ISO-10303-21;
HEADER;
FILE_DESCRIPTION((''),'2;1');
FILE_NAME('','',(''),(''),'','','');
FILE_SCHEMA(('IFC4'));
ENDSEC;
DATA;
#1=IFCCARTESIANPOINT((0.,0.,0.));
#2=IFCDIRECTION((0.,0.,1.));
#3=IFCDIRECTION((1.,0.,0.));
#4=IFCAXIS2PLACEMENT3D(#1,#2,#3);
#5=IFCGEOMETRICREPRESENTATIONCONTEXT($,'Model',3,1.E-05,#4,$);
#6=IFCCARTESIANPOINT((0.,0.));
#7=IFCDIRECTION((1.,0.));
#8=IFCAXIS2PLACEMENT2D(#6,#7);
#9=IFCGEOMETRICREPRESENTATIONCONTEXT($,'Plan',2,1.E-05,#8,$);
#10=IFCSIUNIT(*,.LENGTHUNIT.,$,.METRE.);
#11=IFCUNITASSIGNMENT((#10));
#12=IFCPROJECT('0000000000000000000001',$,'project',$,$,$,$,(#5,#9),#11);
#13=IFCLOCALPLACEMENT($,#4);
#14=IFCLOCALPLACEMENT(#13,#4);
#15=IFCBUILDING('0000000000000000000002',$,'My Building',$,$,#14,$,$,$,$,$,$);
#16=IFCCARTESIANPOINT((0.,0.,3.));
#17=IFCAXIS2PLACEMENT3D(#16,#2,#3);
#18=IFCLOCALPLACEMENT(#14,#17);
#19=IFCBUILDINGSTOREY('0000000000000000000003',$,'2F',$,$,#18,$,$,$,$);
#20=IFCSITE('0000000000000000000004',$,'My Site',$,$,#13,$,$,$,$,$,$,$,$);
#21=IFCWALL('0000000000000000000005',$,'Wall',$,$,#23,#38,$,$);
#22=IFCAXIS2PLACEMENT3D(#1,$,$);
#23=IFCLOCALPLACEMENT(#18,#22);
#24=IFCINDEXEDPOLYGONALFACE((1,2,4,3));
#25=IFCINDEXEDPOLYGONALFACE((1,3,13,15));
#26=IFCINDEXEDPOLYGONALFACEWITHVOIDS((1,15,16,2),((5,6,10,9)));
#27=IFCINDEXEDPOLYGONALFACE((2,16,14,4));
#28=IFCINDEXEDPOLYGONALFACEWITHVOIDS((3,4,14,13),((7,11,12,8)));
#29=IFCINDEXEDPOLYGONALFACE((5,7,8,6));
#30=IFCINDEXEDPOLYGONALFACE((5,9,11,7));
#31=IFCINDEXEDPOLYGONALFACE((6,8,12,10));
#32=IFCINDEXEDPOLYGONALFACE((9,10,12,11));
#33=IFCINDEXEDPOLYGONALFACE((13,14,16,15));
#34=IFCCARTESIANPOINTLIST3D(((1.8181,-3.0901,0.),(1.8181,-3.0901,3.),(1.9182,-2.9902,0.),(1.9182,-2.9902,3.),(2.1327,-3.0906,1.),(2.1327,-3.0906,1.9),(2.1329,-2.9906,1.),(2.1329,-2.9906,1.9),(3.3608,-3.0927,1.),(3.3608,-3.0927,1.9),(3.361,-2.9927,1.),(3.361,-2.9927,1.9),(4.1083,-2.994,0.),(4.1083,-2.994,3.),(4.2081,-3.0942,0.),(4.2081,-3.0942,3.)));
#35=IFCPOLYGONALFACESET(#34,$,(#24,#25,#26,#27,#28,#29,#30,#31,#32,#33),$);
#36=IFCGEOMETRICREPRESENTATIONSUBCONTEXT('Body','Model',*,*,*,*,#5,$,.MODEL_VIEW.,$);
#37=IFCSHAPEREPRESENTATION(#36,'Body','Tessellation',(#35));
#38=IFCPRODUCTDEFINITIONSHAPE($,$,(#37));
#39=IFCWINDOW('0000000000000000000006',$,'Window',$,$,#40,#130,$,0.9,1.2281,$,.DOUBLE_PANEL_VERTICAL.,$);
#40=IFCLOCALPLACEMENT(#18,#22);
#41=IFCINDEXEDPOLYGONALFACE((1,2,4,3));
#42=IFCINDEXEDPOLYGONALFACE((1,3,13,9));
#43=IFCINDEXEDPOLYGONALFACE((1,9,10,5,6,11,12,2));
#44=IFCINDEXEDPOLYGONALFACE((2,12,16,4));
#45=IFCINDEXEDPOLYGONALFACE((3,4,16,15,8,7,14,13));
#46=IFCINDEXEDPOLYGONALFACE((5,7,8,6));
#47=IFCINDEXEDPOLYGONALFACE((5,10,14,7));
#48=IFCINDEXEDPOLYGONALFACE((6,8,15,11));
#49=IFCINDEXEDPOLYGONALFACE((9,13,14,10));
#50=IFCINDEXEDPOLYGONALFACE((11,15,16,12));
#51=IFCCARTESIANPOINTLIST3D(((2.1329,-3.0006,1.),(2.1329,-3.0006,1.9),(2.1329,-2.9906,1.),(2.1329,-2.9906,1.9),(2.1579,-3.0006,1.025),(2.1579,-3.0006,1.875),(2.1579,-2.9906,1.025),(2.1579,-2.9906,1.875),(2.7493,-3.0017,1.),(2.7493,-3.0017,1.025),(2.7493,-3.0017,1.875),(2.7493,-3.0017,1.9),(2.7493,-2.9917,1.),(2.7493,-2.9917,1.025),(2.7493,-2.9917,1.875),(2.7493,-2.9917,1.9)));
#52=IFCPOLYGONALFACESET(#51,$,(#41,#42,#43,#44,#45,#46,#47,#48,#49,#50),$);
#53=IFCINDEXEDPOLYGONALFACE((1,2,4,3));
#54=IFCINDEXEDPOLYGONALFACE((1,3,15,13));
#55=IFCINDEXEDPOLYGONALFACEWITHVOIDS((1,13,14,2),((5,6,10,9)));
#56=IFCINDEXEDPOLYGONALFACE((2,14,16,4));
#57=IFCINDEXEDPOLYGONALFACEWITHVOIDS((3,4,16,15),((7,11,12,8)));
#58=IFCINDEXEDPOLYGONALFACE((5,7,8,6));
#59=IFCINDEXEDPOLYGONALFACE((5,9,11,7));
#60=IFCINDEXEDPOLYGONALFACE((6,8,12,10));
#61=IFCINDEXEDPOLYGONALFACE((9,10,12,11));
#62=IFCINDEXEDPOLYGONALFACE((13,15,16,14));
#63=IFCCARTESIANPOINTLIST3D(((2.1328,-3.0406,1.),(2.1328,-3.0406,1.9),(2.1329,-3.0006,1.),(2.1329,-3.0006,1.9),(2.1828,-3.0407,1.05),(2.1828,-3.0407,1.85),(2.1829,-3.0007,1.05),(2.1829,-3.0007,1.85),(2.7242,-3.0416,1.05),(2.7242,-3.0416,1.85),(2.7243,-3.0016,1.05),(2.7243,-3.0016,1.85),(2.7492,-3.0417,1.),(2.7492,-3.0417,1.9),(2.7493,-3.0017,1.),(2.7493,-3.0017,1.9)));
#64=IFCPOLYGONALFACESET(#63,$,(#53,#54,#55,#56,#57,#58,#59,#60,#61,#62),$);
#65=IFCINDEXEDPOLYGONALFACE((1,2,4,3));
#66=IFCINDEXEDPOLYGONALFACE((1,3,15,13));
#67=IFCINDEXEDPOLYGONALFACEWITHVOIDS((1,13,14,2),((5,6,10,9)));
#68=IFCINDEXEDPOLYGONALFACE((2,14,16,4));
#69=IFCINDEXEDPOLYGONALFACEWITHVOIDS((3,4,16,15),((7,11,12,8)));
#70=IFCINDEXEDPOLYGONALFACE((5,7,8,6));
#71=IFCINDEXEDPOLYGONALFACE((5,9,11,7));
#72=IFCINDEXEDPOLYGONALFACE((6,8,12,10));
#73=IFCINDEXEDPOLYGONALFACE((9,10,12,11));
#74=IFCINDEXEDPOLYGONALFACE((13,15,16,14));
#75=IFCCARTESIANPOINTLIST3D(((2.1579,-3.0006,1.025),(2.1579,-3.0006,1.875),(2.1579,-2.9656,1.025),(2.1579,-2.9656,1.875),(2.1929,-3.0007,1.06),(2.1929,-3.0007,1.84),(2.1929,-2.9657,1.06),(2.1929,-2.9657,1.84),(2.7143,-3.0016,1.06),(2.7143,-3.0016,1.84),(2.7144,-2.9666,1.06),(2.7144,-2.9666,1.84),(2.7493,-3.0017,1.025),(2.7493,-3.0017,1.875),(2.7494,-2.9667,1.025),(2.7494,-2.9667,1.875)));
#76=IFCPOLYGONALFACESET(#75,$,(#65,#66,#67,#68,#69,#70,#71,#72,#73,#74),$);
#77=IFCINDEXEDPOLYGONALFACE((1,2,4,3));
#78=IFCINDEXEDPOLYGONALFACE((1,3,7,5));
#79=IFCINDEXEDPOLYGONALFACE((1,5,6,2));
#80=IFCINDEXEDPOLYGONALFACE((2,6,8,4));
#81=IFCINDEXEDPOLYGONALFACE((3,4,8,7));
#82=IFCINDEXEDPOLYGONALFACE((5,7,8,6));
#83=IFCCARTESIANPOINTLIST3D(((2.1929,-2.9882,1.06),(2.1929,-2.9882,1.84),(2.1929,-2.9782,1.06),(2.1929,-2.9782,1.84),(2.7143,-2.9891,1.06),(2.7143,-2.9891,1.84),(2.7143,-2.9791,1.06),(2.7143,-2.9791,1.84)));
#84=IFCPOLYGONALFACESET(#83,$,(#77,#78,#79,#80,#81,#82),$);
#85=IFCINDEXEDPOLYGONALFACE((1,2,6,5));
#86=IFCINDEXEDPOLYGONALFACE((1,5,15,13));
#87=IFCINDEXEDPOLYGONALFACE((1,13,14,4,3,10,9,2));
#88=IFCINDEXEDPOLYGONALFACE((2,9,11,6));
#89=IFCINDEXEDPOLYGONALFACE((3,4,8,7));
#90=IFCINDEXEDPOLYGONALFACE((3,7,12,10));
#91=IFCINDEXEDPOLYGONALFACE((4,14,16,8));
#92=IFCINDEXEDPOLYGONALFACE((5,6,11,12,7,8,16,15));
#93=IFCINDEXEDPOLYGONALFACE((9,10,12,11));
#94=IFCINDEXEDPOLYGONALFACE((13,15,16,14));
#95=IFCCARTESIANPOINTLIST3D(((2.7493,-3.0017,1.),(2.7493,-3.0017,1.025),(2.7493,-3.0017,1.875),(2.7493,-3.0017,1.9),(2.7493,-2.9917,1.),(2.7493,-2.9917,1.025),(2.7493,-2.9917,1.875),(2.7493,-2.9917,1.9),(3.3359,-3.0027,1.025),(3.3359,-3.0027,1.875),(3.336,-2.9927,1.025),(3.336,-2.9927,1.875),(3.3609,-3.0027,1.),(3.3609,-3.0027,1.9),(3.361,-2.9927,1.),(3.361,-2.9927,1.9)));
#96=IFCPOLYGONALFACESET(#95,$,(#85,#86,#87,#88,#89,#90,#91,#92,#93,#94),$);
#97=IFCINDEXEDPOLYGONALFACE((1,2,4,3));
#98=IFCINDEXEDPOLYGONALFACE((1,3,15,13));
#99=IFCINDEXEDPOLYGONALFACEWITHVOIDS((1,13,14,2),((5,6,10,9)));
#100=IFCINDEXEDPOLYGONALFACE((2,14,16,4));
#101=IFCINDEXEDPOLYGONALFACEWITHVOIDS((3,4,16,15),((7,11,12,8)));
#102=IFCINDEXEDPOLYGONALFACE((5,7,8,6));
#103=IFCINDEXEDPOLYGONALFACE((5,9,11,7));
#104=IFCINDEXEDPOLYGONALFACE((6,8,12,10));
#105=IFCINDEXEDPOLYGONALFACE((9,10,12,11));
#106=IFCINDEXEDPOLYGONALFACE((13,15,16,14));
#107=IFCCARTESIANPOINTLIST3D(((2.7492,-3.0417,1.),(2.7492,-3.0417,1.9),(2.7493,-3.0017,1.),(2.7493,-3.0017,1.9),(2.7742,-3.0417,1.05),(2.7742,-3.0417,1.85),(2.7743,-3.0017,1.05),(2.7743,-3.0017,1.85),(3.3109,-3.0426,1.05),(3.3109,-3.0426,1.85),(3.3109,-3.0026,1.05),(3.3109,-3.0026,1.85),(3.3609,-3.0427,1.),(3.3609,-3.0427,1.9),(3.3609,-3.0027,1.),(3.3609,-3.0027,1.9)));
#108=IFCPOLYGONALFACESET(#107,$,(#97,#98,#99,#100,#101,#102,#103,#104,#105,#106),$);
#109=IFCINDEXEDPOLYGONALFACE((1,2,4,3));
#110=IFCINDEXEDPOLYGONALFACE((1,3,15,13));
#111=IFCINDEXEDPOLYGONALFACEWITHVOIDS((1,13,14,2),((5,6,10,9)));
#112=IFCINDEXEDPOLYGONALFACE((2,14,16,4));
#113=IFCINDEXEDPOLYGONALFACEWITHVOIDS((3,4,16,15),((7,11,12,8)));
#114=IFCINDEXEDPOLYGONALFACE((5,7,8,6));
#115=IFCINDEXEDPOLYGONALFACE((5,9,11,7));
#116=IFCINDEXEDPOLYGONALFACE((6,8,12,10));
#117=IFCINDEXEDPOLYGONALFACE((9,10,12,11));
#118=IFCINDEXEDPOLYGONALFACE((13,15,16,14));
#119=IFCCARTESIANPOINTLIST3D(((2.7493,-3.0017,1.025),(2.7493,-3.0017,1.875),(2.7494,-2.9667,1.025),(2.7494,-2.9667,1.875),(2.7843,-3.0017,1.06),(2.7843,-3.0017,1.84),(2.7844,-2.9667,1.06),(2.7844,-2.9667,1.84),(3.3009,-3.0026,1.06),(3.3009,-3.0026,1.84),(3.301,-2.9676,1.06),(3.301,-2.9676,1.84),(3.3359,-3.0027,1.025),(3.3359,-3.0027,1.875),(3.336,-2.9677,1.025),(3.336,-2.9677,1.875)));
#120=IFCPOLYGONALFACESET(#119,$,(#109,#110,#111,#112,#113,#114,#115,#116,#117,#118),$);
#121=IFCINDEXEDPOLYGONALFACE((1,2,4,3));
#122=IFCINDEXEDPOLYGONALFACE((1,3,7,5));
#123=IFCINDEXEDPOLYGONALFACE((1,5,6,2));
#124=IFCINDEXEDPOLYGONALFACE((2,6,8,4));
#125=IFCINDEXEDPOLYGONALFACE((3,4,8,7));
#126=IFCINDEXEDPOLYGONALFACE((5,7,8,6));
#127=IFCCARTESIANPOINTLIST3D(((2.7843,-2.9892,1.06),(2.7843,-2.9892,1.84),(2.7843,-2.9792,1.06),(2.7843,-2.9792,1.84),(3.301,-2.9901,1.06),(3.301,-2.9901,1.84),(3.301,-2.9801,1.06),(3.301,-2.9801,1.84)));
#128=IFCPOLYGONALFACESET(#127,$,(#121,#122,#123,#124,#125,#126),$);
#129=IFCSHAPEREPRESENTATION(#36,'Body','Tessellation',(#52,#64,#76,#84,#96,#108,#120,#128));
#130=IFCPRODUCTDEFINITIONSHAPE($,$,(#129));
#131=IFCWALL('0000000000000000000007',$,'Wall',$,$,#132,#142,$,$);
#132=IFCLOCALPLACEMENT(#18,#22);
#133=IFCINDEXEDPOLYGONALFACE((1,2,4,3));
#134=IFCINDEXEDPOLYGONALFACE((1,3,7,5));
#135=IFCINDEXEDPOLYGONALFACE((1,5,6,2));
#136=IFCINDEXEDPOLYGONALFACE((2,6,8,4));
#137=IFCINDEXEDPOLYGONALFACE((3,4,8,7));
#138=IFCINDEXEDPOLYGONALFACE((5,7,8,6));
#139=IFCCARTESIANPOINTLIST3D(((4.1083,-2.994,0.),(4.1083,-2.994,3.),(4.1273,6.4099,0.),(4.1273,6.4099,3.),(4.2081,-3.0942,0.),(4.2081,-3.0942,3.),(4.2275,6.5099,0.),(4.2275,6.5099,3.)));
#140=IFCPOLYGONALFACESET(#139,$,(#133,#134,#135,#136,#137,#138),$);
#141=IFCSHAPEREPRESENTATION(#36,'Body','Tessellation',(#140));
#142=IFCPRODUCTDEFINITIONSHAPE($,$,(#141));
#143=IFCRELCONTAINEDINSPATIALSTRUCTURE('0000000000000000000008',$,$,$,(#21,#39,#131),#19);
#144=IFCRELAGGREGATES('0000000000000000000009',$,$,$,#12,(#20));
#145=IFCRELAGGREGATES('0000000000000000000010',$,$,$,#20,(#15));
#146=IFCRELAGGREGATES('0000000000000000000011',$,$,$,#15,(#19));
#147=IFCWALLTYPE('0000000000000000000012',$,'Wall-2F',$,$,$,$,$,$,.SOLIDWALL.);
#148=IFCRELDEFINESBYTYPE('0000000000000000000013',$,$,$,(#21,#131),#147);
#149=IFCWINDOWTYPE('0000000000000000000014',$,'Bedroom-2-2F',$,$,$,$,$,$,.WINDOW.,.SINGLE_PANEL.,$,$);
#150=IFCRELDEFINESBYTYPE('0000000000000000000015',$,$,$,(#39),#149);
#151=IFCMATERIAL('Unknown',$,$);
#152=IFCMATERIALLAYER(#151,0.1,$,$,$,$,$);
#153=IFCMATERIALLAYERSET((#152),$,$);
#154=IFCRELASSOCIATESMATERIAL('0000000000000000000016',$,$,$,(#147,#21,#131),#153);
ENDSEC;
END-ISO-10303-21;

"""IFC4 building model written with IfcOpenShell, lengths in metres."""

from ifc_helpers import new_model, entity, si_unit, frame, origin_with_axes, origin_2d_with_axis, place, context, subcontext, project, spatial, line, indexed_curve, outline, extrude, shape, source, transform, mapped, material, layer, layer_set, layer_usage, type_object, type_shapes, element, fill, save


model = new_model("IFC4")

# Units and contexts
model_context = context("Model", 3, precision=1e-05, world=origin_with_axes())
plan_context = context("Plan", 2, precision=1e-05, world=origin_2d_with_axis())
body_context_1 = subcontext(model_context, "Body", "Model", "MODEL_VIEW")
body_context_2 = subcontext(plan_context, "Body", "Plan", "PLAN_VIEW")
ifc_project = project(units=[si_unit("LENGTHUNIT", "METRE")], contexts=[model_context, plan_context])

# Site, building, storey
site_placement = place(None, origin_with_axes())
site = spatial("IfcSite", under=ifc_project, at=site_placement, Name="My Site")
building_placement = place(site_placement, origin_with_axes())
building = spatial("IfcBuilding", under=site, at=building_placement, Name="My Building")
storey_placement = place(building_placement, frame((0.0, 0.0, 3.0), z_axis=(0.0, 0.0, 1.0), x_axis=(1.0, 0.0, 0.0)))
storey = spatial("IfcBuildingStorey", under=building, at=storey_placement, Name="2F")

# Shared definitions
ifc_material = material(Name="Unknown")

# Shared definitions
ifc_layer_1 = layer(ifc_material, 0.1)
ifc_layer_set_1 = layer_set([ifc_layer_1])
wall_type = type_object("IfcWallType", Name="Wall-2F", PredefinedType="SOLIDWALL", material=ifc_layer_set_1)

# Wall, opening, window
ifc_layer_usage_1 = layer_usage(ifc_layer_set_1, "AXIS2", "POSITIVE", 0.0)
wall_1_placement = place(storey_placement, frame((1.8181, -3.0901, 0.0), z_axis=(0.0, 0.0, 1.0), x_axis=(0.999999, -0.001718, 0.0)))
wall_1 = element("IfcWall", 1, at=wall_1_placement, inside=storey, type_object=wall_type, material=ifc_layer_usage_1, Name="Wall", context=body_context_1, shape_type="SweptSolid", body=[
    extrude(outline(indexed_curve([(0.0, 0.0), (0.1, 0.1), (2.29, 0.1), (2.39, 0.0)], segments=[line(1, 2, 3, 4, 1)])), origin_with_axes(), (0.0, 0.0, 1.0), 3.0),
])
shared_shape_1 = source(origin_with_axes(), body_context_1, "Body", "SweptSolid", [
    extrude(outline(indexed_curve([(0.0, 0.0), (1.2281, 0.0), (1.2281, 0.9), (0.0, 0.9)], segments=[line(1, 2, 3, 4, 1)])), frame((0.0, -0.6, 0.0), z_axis=(0.0, -1.0, 0.0), x_axis=(1.0, 0.0, 0.0)), (0.0, 0.0, -1.0), 1.2),
])
opening_1_placement = place(wall_1_placement, frame((0.3146, 0.0, 1.0), z_axis=(0.0, 0.0, 1.0), x_axis=(1.0, -0.000001, 0.0)))
opening_1 = element("IfcOpeningElement", 2, at=opening_1_placement, cuts=wall_1, PredefinedType="OPENING", context=body_context_1, shape_type="MappedRepresentation", body=[
    mapped(shared_shape_1, transform((0.0, 0.0, 0.0), x_axis=(1.0, 0.0, 0.0), y_axis=(0.0, 1.0, 0.0), z_axis=(0.0, 0.0, 1.0), scale=1.0)),
])
window_type = type_object("IfcWindowType", Name="Bedroom-2-2F", PartitioningType="SINGLE_PANEL", PredefinedType="WINDOW")
shared_shape_2 = source(origin_with_axes(), body_context_1, "Body", "SweptSolid", [
    extrude(outline(indexed_curve([(0.6164, 0.0), (0.0, 0.0), (0.0, 0.9), (0.6164, 0.9), (0.6164, 0.875), (0.025, 0.875), (0.025, 0.025), (0.6164, 0.025)], segments=[line(1, 2, 3, 4, 5, 6, 7, 8, 1)])), frame((0.0, 0.09, 0.0), z_axis=(0.0, -1.0, 0.0), x_axis=(1.0, 0.0, 0.0)), (0.0, 0.0, -1.0), 0.01),
    extrude(outline(indexed_curve([(0.0, 0.0), (0.6164, 0.0), (0.6164, 0.9), (0.0, 0.9)], segments=[line(1, 2, 3, 4, 1)]), holes=[indexed_curve([(0.05, 0.05), (0.5914, 0.05), (0.5914, 0.85), (0.05, 0.85)], segments=[line(1, 2, 3, 4, 1)])]), frame((0.0, 0.05, 0.0), z_axis=(0.0, -1.0, 0.0), x_axis=(1.0, 0.0, 0.0)), (0.0, 0.0, -1.0), 0.04),
    extrude(outline(indexed_curve([(0.0, 0.0), (0.5914, 0.0), (0.5914, 0.85), (0.0, 0.85)], segments=[line(1, 2, 3, 4, 1)]), holes=[indexed_curve([(0.035, 0.035), (0.5564, 0.035), (0.5564, 0.815), (0.035, 0.815)], segments=[line(1, 2, 3, 4, 1)])]), frame((0.025, 0.09, 0.025), z_axis=(0.0, -1.0, 0.0), x_axis=(1.0, 0.0, 0.0)), (0.0, 0.0, -1.0), 0.035),
    extrude(outline(indexed_curve([(0.035, 0.035), (0.5564, 0.035), (0.5564, 0.815), (0.035, 0.815)], segments=[line(1, 2, 3, 4, 1)])), frame((0.025, 0.1025, 0.025), z_axis=(0.0, -1.0, 0.0), x_axis=(1.0, 0.0, 0.0)), (0.0, 0.0, -1.0), 0.01),
    extrude(outline(indexed_curve([(0.0, 0.9), (0.6116, 0.9), (0.6116, 0.0), (0.0, 0.0), (0.0, 0.025), (0.5866, 0.025), (0.5866, 0.875), (0.0, 0.875)], segments=[line(1, 2, 3, 4, 5, 6, 7, 8, 1)])), frame((0.6164, 0.09, 0.0), z_axis=(0.0, -1.0, 0.0), x_axis=(1.0, 0.0, 0.0)), (0.0, 0.0, -1.0), 0.01),
    extrude(outline(indexed_curve([(0.0, 0.0), (0.6116, 0.0), (0.6116, 0.9), (0.0, 0.9)], segments=[line(1, 2, 3, 4, 1)]), holes=[indexed_curve([(0.025, 0.05), (0.5616, 0.05), (0.5616, 0.85), (0.025, 0.85)], segments=[line(1, 2, 3, 4, 1)])]), frame((0.6164, 0.05, 0.0), z_axis=(0.0, -1.0, 0.0), x_axis=(1.0, 0.0, 0.0)), (0.0, 0.0, -1.0), 0.04),
    extrude(outline(indexed_curve([(0.0, 0.0), (0.5866, 0.0), (0.5866, 0.85), (0.0, 0.85)], segments=[line(1, 2, 3, 4, 1)]), holes=[indexed_curve([(0.035, 0.035), (0.5516, 0.035), (0.5516, 0.815), (0.035, 0.815)], segments=[line(1, 2, 3, 4, 1)])]), frame((0.6164, 0.09, 0.025), z_axis=(0.0, -1.0, 0.0), x_axis=(1.0, 0.0, 0.0)), (0.0, 0.0, -1.0), 0.035),
    extrude(outline(indexed_curve([(0.035, 0.035), (0.5516, 0.035), (0.5516, 0.815), (0.035, 0.815)], segments=[line(1, 2, 3, 4, 1)])), frame((0.6164, 0.1025, 0.025), z_axis=(0.0, -1.0, 0.0), x_axis=(1.0, 0.0, 0.0)), (0.0, 0.0, -1.0), 0.01),
])
shared_shape_3 = source(origin_with_axes(), body_context_2, "Body", "Curve2D", [
    entity("IfcIndexedPolyCurve", entity("IfcCartesianPointList2D", [[0.05, 0.05], [0.5914, 0.05]])),
    entity("IfcIndexedPolyCurve", entity("IfcCartesianPointList2D", [[0.0, 0.1], [0.025, 0.1], [0.025, 0.09], [0.05, 0.09], [0.05, 0.05], [0.0, 0.05]]), [entity("IfcLineIndex", [1, 2, 3, 4, 5, 6, 1])]),
    entity("IfcIndexedPolyCurve", entity("IfcCartesianPointList2D", [[0.6164, 0.1], [0.6164, 0.1], [0.6164, 0.09], [0.5914, 0.09], [0.5914, 0.05], [0.6164, 0.05]])),
    entity("IfcIndexedPolyCurve", entity("IfcCartesianPointList2D", [[0.025, 0.09], [0.06, 0.09], [0.06, 0.125], [0.025, 0.125]]), [entity("IfcLineIndex", [1, 2, 3, 4, 1])]),
    entity("IfcIndexedPolyCurve", entity("IfcCartesianPointList2D", [[0.6164, 0.09], [0.5814, 0.09], [0.5814, 0.125], [0.6164, 0.125]]), [entity("IfcLineIndex", [1, 2, 3, 4, 1])]),
    entity("IfcIndexedPolyCurve", entity("IfcCartesianPointList2D", [[0.06, 0.09], [0.5814, 0.09]])),
    entity("IfcIndexedPolyCurve", entity("IfcCartesianPointList2D", [[0.06, 0.125], [0.5814, 0.125]])),
    entity("IfcIndexedPolyCurve", entity("IfcCartesianPointList2D", [[0.06, 0.1075], [0.5814, 0.1075]])),
    entity("IfcIndexedPolyCurve", entity("IfcCartesianPointList2D", [[0.6414, 0.05], [1.1781, 0.05]])),
    entity("IfcIndexedPolyCurve", entity("IfcCartesianPointList2D", [[0.6164, 0.1], [0.6164, 0.1], [0.6164, 0.09], [0.6414, 0.09], [0.6414, 0.05], [0.6164, 0.05]])),
    entity("IfcIndexedPolyCurve", entity("IfcCartesianPointList2D", [[1.2281, 0.1], [1.2031, 0.1], [1.2031, 0.09], [1.1781, 0.09], [1.1781, 0.05], [1.2281, 0.05]]), [entity("IfcLineIndex", [1, 2, 3, 4, 5, 6, 1])]),
    entity("IfcIndexedPolyCurve", entity("IfcCartesianPointList2D", [[0.6164, 0.09], [0.6514, 0.09], [0.6514, 0.125], [0.6164, 0.125]]), [entity("IfcLineIndex", [1, 2, 3, 4, 1])]),
    entity("IfcIndexedPolyCurve", entity("IfcCartesianPointList2D", [[1.2031, 0.09], [1.1681, 0.09], [1.1681, 0.125], [1.2031, 0.125]]), [entity("IfcLineIndex", [1, 2, 3, 4, 1])]),
    entity("IfcIndexedPolyCurve", entity("IfcCartesianPointList2D", [[0.6514, 0.09], [1.1681, 0.09]])),
    entity("IfcIndexedPolyCurve", entity("IfcCartesianPointList2D", [[0.6514, 0.125], [1.1681, 0.125]])),
    entity("IfcIndexedPolyCurve", entity("IfcCartesianPointList2D", [[0.6514, 0.1075], [1.1681, 0.1075]])),
])
type_shapes(window_type, [shared_shape_2, shared_shape_3])
window_placement = place(opening_1_placement, frame((0.0, 0.0, 0.0), z_axis=(0.0, 0.0, 1.0), x_axis=(1.0, 0.0, 0.0)))
window = element("IfcWindow", 3, at=window_placement, inside=storey, type_object=window_type, Name="Window", OverallHeight=0.9, OverallWidth=1.2281, PartitioningType="DOUBLE_PANEL_VERTICAL", shapes=[
    shape(body_context_1, "Body", "MappedRepresentation", [mapped(shared_shape_2, transform((0.0, 0.0, 0.0), x_axis=(1.0, 0.0, 0.0), y_axis=(0.0, 1.0, 0.0), z_axis=(0.0, 0.0, 1.0), scale=1.0))]),
    shape(body_context_2, "Body", "MappedRepresentation", [mapped(shared_shape_3, transform((0.0, 0.0, 0.0), x_axis=(1.0, 0.0, 0.0), y_axis=(0.0, 1.0, 0.0), z_axis=(0.0, 0.0, 1.0), scale=1.0))]),
])
fill(opening_1, window)

# Wall
ifc_layer_usage_2 = layer_usage(ifc_layer_set_1, "AXIS2", "POSITIVE", 0.0)
wall_2_placement = place(storey_placement, frame((4.2081, -3.0942, 0.0), z_axis=(0.0, 0.0, 1.0), x_axis=(0.002021, 0.999998, 0.0)))
element("IfcWall", 4, at=wall_2_placement, inside=storey, type_object=wall_type, material=ifc_layer_usage_2, Name="Wall", context=body_context_1, shape_type="SweptSolid", body=[
    extrude(outline(indexed_curve([(0.0, 0.0), (0.1, 0.1), (9.5039, 0.1), (9.6041, 0.0)], segments=[line(1, 2, 3, 4, 1)])), origin_with_axes(), (0.0, 0.0, 1.0), 3.0),
])

save(model, "model.ifc")
